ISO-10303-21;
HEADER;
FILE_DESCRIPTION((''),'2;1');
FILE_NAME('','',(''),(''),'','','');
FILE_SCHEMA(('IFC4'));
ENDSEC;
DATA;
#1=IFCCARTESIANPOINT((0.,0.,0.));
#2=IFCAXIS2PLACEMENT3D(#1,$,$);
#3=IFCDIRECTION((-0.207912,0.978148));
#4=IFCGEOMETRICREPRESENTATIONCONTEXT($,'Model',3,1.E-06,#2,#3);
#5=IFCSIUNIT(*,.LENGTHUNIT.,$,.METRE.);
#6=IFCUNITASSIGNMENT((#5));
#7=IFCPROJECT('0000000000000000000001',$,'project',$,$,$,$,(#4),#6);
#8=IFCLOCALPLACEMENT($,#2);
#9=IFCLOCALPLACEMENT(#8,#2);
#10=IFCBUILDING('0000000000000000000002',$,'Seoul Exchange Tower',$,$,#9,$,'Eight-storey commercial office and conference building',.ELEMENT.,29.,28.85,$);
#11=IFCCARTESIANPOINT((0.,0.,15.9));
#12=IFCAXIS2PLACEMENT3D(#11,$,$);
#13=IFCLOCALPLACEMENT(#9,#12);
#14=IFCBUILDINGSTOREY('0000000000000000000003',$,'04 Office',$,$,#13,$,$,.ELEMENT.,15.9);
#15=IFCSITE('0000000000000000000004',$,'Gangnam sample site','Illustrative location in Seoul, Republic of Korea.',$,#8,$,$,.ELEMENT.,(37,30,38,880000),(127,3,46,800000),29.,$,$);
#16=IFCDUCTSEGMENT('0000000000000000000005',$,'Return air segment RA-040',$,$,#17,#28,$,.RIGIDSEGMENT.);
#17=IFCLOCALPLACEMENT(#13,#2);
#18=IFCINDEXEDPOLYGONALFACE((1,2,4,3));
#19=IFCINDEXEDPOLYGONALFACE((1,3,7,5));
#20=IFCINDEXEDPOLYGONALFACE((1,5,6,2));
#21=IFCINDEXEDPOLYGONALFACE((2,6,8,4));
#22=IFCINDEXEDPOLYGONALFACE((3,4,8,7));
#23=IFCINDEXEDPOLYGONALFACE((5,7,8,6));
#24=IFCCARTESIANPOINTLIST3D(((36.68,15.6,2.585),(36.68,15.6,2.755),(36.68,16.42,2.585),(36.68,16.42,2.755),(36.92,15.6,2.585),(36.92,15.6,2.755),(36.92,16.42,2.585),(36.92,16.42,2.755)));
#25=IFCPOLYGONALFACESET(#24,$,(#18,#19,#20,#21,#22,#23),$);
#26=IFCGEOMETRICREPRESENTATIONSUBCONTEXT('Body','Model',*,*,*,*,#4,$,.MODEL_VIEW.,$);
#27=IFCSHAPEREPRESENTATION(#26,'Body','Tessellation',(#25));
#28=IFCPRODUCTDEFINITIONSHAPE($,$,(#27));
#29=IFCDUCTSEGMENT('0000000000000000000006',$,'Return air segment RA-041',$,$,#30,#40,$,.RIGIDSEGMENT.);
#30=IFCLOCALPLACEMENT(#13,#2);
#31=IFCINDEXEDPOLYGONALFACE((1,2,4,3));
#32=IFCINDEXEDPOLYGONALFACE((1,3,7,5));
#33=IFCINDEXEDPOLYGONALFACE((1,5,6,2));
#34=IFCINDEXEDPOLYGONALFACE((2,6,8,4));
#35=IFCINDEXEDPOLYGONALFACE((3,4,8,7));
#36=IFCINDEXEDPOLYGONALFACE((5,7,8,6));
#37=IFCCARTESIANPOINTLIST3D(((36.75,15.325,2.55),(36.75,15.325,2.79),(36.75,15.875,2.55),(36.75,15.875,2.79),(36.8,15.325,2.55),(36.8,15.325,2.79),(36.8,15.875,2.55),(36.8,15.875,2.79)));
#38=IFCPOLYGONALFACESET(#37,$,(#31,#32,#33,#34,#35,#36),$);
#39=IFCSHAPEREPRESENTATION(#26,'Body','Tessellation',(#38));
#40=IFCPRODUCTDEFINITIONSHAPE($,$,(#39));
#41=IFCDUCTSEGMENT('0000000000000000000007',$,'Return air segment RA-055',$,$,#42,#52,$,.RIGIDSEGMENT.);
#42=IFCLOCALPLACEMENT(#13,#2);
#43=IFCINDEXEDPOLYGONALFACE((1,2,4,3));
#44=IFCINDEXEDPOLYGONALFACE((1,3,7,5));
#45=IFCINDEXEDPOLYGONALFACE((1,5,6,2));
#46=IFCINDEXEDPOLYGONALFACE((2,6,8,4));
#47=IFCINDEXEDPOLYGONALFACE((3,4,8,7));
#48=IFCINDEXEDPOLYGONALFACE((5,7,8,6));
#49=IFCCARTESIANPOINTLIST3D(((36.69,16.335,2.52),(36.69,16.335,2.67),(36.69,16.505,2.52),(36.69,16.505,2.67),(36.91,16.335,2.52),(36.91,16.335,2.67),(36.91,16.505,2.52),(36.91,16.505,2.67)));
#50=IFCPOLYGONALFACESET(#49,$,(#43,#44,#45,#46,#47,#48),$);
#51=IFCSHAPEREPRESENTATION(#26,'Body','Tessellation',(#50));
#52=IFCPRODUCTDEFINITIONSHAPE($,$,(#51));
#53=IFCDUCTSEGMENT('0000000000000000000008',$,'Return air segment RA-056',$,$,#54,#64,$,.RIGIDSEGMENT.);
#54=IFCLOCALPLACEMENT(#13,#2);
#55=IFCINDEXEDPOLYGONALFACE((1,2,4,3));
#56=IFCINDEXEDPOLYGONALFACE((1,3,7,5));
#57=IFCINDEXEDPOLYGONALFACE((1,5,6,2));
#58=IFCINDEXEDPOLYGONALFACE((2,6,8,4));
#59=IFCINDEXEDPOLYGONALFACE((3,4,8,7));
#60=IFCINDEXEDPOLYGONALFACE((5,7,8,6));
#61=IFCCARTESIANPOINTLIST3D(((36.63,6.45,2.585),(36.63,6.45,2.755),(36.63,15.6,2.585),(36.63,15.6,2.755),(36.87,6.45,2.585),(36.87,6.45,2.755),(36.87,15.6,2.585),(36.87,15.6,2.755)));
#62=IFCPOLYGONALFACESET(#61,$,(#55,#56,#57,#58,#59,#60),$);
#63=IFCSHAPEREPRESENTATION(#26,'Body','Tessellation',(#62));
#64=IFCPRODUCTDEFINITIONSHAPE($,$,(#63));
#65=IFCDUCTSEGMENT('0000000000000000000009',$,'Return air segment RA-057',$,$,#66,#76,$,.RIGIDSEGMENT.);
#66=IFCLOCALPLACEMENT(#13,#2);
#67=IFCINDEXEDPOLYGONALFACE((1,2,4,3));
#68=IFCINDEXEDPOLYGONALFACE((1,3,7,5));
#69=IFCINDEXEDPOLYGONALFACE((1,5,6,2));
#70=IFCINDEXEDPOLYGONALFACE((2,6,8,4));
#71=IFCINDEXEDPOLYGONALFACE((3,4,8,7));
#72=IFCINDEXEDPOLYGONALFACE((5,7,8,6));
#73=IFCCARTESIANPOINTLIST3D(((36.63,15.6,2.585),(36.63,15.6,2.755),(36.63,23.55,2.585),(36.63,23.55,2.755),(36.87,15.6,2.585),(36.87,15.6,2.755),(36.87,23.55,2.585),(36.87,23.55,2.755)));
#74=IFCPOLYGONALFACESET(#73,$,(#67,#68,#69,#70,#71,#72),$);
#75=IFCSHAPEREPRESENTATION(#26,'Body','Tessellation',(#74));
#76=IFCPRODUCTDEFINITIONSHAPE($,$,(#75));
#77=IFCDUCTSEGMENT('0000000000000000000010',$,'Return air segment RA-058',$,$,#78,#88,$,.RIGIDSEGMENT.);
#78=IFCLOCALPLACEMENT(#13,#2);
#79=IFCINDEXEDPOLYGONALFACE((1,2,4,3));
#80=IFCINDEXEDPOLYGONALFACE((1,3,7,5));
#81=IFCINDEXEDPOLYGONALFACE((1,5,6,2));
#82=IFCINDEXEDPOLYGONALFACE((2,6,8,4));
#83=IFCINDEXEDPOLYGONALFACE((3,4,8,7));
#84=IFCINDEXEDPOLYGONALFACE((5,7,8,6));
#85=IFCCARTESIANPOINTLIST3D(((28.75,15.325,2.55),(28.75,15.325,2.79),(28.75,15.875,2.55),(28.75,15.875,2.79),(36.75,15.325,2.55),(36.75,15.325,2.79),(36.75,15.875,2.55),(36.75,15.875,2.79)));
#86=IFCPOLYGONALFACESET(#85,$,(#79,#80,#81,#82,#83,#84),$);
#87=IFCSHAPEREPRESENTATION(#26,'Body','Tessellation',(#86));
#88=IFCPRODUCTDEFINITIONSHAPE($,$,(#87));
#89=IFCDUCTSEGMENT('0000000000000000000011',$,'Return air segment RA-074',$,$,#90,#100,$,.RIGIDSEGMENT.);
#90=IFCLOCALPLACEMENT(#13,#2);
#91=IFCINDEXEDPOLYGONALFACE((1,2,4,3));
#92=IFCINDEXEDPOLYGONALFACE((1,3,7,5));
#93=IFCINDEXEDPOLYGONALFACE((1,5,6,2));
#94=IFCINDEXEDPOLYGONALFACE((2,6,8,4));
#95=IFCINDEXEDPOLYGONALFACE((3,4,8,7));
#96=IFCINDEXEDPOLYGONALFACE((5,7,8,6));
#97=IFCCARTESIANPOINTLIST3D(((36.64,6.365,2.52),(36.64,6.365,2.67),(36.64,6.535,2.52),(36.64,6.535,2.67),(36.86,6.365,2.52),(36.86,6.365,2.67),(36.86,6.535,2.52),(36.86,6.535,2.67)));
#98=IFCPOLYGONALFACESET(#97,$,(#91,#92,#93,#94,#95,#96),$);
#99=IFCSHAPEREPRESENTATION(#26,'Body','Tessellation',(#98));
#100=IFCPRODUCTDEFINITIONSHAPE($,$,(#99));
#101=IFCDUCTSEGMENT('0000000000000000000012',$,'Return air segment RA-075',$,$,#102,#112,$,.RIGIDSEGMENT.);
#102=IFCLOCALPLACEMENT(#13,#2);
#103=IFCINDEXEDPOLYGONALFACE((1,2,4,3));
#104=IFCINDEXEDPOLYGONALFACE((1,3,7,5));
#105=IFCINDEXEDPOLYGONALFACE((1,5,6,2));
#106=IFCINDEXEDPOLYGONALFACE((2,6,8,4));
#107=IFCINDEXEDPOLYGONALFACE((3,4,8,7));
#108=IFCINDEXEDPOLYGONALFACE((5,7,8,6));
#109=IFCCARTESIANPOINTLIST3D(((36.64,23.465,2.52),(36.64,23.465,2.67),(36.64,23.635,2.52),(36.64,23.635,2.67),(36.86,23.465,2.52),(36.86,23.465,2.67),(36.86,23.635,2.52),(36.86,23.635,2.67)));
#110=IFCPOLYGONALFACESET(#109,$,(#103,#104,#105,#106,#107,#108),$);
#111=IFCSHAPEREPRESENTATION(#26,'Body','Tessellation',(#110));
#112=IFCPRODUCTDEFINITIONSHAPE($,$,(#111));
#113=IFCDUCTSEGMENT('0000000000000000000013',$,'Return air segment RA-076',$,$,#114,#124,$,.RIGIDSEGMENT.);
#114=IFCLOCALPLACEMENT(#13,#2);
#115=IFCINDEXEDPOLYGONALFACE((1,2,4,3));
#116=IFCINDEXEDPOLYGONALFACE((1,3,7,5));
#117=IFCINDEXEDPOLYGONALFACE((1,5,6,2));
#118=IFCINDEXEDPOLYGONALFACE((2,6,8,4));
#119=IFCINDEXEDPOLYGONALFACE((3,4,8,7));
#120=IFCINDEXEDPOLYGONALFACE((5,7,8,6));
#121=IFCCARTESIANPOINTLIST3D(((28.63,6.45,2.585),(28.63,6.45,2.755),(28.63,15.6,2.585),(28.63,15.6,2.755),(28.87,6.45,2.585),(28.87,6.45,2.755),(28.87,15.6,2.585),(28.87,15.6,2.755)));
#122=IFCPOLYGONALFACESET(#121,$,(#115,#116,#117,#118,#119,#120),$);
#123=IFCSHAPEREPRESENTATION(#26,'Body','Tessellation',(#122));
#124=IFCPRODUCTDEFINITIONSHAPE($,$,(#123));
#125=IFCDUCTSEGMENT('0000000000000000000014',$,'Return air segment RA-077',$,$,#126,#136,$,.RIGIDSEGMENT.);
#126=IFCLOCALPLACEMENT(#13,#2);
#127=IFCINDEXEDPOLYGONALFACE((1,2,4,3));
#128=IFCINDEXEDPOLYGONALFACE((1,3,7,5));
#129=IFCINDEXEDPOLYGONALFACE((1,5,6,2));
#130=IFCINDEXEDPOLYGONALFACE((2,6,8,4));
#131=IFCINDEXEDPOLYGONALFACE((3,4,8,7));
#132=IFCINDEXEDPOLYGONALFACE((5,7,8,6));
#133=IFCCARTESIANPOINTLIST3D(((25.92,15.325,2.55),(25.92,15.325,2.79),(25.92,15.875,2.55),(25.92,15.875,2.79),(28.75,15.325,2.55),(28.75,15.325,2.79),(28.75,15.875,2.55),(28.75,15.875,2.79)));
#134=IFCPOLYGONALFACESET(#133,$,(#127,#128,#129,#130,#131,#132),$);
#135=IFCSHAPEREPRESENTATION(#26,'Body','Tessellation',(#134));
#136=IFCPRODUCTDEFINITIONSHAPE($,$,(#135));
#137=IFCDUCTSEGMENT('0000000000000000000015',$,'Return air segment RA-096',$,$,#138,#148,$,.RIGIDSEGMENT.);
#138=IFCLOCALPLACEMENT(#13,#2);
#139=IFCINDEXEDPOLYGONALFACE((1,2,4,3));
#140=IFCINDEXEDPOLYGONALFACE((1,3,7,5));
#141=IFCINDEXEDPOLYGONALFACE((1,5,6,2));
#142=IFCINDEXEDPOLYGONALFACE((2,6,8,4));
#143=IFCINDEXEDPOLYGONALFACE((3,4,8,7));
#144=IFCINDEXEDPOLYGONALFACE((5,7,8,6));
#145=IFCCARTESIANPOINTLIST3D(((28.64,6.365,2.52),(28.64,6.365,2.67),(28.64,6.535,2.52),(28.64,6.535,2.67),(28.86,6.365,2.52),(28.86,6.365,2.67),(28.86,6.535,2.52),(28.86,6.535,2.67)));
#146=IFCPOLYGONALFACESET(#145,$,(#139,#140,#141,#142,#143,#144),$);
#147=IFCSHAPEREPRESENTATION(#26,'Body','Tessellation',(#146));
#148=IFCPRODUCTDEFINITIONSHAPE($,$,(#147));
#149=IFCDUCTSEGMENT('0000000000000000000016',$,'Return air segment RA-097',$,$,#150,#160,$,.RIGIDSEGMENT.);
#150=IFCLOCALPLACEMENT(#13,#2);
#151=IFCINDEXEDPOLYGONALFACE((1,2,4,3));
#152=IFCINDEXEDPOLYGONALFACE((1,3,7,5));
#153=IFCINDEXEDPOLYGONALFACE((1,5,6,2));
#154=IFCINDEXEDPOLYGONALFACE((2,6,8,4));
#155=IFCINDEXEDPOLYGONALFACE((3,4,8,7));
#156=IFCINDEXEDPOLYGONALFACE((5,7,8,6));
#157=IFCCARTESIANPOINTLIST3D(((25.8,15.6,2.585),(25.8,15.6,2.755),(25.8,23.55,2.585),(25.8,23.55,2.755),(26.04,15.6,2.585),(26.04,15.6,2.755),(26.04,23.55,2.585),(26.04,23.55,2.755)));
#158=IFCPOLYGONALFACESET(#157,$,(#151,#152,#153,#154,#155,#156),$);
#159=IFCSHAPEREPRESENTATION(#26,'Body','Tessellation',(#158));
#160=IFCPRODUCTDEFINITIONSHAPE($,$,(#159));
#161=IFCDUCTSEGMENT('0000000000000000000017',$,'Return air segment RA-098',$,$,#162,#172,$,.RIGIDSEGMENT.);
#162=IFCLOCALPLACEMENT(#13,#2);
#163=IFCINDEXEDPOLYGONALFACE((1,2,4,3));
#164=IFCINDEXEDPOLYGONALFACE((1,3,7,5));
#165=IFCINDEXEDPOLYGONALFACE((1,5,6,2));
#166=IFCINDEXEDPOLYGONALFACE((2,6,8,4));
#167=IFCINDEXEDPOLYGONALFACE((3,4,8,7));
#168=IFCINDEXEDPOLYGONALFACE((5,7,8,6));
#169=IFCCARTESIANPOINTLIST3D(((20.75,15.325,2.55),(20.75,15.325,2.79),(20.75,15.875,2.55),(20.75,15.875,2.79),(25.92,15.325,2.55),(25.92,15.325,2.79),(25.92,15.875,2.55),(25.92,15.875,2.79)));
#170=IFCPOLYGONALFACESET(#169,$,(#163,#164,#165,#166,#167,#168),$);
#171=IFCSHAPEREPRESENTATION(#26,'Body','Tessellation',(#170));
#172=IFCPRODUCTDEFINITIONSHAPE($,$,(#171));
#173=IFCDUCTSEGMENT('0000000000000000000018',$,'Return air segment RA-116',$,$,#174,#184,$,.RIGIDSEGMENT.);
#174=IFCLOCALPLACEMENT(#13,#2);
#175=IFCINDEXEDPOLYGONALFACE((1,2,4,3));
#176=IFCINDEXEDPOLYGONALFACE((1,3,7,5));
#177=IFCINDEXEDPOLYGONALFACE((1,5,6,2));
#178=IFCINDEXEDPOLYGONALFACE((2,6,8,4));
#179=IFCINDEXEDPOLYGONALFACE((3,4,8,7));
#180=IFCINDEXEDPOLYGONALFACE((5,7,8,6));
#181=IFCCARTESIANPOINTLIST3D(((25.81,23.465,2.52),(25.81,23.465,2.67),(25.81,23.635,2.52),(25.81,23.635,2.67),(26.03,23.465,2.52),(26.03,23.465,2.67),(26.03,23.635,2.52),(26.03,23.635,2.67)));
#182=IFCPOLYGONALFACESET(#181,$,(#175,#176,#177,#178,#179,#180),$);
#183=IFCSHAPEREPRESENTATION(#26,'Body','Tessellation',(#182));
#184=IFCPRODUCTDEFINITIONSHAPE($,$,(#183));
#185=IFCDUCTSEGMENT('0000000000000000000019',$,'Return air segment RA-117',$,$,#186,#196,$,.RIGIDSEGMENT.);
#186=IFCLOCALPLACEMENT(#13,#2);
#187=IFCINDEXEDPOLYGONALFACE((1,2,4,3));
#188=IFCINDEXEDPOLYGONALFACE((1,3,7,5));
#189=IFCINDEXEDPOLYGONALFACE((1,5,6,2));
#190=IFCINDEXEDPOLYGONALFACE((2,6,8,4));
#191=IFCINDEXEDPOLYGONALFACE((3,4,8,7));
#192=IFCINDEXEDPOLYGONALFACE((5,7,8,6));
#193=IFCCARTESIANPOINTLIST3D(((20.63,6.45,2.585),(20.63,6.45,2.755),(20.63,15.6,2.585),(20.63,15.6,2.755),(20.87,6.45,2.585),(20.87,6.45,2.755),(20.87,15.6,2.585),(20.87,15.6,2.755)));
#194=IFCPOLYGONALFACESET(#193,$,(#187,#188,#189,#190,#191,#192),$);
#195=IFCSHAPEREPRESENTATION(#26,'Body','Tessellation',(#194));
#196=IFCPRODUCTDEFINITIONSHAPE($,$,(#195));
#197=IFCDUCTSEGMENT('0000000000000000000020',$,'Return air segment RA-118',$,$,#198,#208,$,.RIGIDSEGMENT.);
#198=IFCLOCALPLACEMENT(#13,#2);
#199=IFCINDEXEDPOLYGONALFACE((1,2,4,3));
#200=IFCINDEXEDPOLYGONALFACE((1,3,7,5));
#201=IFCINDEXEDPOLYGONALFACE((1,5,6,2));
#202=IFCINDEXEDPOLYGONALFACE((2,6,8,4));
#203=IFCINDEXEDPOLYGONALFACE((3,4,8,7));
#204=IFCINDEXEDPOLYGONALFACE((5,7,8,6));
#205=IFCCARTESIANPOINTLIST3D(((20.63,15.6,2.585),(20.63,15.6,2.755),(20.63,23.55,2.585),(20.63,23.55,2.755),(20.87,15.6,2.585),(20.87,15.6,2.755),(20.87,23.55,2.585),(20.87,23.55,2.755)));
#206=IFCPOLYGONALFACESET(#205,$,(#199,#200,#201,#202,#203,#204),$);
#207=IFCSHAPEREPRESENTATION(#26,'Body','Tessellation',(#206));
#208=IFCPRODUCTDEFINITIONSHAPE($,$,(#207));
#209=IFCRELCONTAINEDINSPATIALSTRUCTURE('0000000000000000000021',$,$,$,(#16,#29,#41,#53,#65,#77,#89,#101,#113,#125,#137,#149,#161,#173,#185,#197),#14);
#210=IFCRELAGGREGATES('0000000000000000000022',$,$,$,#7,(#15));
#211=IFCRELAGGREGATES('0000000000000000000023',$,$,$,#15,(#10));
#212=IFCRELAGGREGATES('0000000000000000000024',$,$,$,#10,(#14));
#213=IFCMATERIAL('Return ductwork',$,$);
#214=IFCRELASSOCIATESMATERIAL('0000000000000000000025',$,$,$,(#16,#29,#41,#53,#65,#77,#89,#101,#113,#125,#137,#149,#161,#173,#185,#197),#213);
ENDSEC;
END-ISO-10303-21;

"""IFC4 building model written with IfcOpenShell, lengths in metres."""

from ifc_helpers import new_model, si_unit, direction, frame, origin, place, context, subcontext, project, spatial, rectangle, extrude, material, element, save


model = new_model("IFC4")

# Units and contexts
model_context = context("Model", 3, precision=1e-06, world=origin(), true_north=direction((-0.207912, 0.978148)))
body_context = subcontext(model_context, "Body", "Model", "MODEL_VIEW")
ifc_project = project(units=[si_unit("LENGTHUNIT", "METRE")], contexts=[model_context])

# Site, building, storey
site_placement = place(None, origin())
site = spatial("IfcSite", under=ifc_project, at=site_placement, Name="Gangnam sample site", Description="Illustrative location in Seoul, Republic of Korea.", CompositionType="ELEMENT", RefLatitude=(37, 30, 38, 880000), RefLongitude=(127, 3, 46, 800000), RefElevation=29.0)
building_placement = place(site_placement, origin())
building = spatial("IfcBuilding", under=site, at=building_placement, Name="Seoul Exchange Tower", LongName="Eight-storey commercial office and conference building", CompositionType="ELEMENT", ElevationOfRefHeight=29.0, ElevationOfTerrain=28.85)
storey_placement = place(building_placement, frame((0.0, 0.0, 15.9)))
storey = spatial("IfcBuildingStorey", under=building, at=storey_placement, Name="04 Office", CompositionType="ELEMENT", Elevation=15.9)

# Shared definitions
ifc_material = material(Name="Return ductwork")
placement = place(storey_placement, origin())

# Duct segments
element("IfcDuctSegment", 1, at=placement, inside=storey, material=ifc_material, Name="Return air segment RA-040", PredefinedType="RIGIDSEGMENT", context=body_context, shape_type="SweptSolid", body=[
    extrude(rectangle(XDim=0.24, YDim=0.17), frame((36.8, 16.42, 2.67), z_axis=(0.0, -1.0, 0.0), x_axis=(1.0, 0.0, 0.0)), (0.0, 0.0, 1.0), 0.82),
])
element("IfcDuctSegment", 2, at=placement, inside=storey, material=ifc_material, Name="Return air segment RA-041", PredefinedType="RIGIDSEGMENT", context=body_context, shape_type="SweptSolid", body=[
    extrude(rectangle(XDim=0.55, YDim=0.24), frame((36.75, 15.6, 2.67), z_axis=(1.0, 0.0, 0.0), x_axis=(0.0, 1.0, 0.0)), (0.0, 0.0, 1.0), 0.05),
])
element("IfcDuctSegment", 3, at=placement, inside=storey, material=ifc_material, Name="Return air segment RA-055", PredefinedType="RIGIDSEGMENT", context=body_context, shape_type="SweptSolid", body=[
    extrude(rectangle(XDim=0.22, YDim=0.17), frame((36.8, 16.42, 2.52), z_axis=(0.0, 0.0, 1.0), x_axis=(1.0, 0.0, 0.0)), (0.0, 0.0, 1.0), 0.15),
])
element("IfcDuctSegment", 4, at=placement, inside=storey, material=ifc_material, Name="Return air segment RA-056", PredefinedType="RIGIDSEGMENT", context=body_context, shape_type="SweptSolid", body=[
    extrude(rectangle(XDim=0.24, YDim=0.17), frame((36.75, 6.45, 2.67), z_axis=(0.0, 1.0, 0.0), x_axis=(1.0, 0.0, 0.0)), (0.0, 0.0, 1.0), 9.15),
])
element("IfcDuctSegment", 5, at=placement, inside=storey, material=ifc_material, Name="Return air segment RA-057", PredefinedType="RIGIDSEGMENT", context=body_context, shape_type="SweptSolid", body=[
    extrude(rectangle(XDim=0.24, YDim=0.17), frame((36.75, 23.55, 2.67), z_axis=(0.0, -1.0, 0.0), x_axis=(1.0, 0.0, 0.0)), (0.0, 0.0, 1.0), 7.95),
])
element("IfcDuctSegment", 6, at=placement, inside=storey, material=ifc_material, Name="Return air segment RA-058", PredefinedType="RIGIDSEGMENT", context=body_context, shape_type="SweptSolid", body=[
    extrude(rectangle(XDim=0.55, YDim=0.24), frame((28.75, 15.6, 2.67), z_axis=(1.0, 0.0, 0.0), x_axis=(0.0, 1.0, 0.0)), (0.0, 0.0, 1.0), 8.0),
])
element("IfcDuctSegment", 7, at=placement, inside=storey, material=ifc_material, Name="Return air segment RA-074", PredefinedType="RIGIDSEGMENT", context=body_context, shape_type="SweptSolid", body=[
    extrude(rectangle(XDim=0.22, YDim=0.17), frame((36.75, 6.45, 2.52), z_axis=(0.0, 0.0, 1.0), x_axis=(1.0, 0.0, 0.0)), (0.0, 0.0, 1.0), 0.15),
])
element("IfcDuctSegment", 8, at=placement, inside=storey, material=ifc_material, Name="Return air segment RA-075", PredefinedType="RIGIDSEGMENT", context=body_context, shape_type="SweptSolid", body=[
    extrude(rectangle(XDim=0.22, YDim=0.17), frame((36.75, 23.55, 2.52), z_axis=(0.0, 0.0, 1.0), x_axis=(1.0, 0.0, 0.0)), (0.0, 0.0, 1.0), 0.15),
])
element("IfcDuctSegment", 9, at=placement, inside=storey, material=ifc_material, Name="Return air segment RA-076", PredefinedType="RIGIDSEGMENT", context=body_context, shape_type="SweptSolid", body=[
    extrude(rectangle(XDim=0.24, YDim=0.17), frame((28.75, 6.45, 2.67), z_axis=(0.0, 1.0, 0.0), x_axis=(1.0, 0.0, 0.0)), (0.0, 0.0, 1.0), 9.15),
])
element("IfcDuctSegment", 10, at=placement, inside=storey, material=ifc_material, Name="Return air segment RA-077", PredefinedType="RIGIDSEGMENT", context=body_context, shape_type="SweptSolid", body=[
    extrude(rectangle(XDim=0.55, YDim=0.24), frame((25.92, 15.6, 2.67), z_axis=(1.0, 0.0, 0.0), x_axis=(0.0, 1.0, 0.0)), (0.0, 0.0, 1.0), 2.83),
])
element("IfcDuctSegment", 11, at=placement, inside=storey, material=ifc_material, Name="Return air segment RA-096", PredefinedType="RIGIDSEGMENT", context=body_context, shape_type="SweptSolid", body=[
    extrude(rectangle(XDim=0.22, YDim=0.17), frame((28.75, 6.45, 2.52), z_axis=(0.0, 0.0, 1.0), x_axis=(1.0, 0.0, 0.0)), (0.0, 0.0, 1.0), 0.15),
])
element("IfcDuctSegment", 12, at=placement, inside=storey, material=ifc_material, Name="Return air segment RA-097", PredefinedType="RIGIDSEGMENT", context=body_context, shape_type="SweptSolid", body=[
    extrude(rectangle(XDim=0.24, YDim=0.17), frame((25.92, 23.55, 2.67), z_axis=(0.0, -1.0, 0.0), x_axis=(1.0, 0.0, 0.0)), (0.0, 0.0, 1.0), 7.95),
])
element("IfcDuctSegment", 13, at=placement, inside=storey, material=ifc_material, Name="Return air segment RA-098", PredefinedType="RIGIDSEGMENT", context=body_context, shape_type="SweptSolid", body=[
    extrude(rectangle(XDim=0.55, YDim=0.24), frame((20.75, 15.6, 2.67), z_axis=(1.0, 0.0, 0.0), x_axis=(0.0, 1.0, 0.0)), (0.0, 0.0, 1.0), 5.17),
])
element("IfcDuctSegment", 14, at=placement, inside=storey, material=ifc_material, Name="Return air segment RA-116", PredefinedType="RIGIDSEGMENT", context=body_context, shape_type="SweptSolid", body=[
    extrude(rectangle(XDim=0.22, YDim=0.17), frame((25.92, 23.55, 2.52), z_axis=(0.0, 0.0, 1.0), x_axis=(1.0, 0.0, 0.0)), (0.0, 0.0, 1.0), 0.15),
])
element("IfcDuctSegment", 15, at=placement, inside=storey, material=ifc_material, Name="Return air segment RA-117", PredefinedType="RIGIDSEGMENT", context=body_context, shape_type="SweptSolid", body=[
    extrude(rectangle(XDim=0.24, YDim=0.17), frame((20.75, 6.45, 2.67), z_axis=(0.0, 1.0, 0.0), x_axis=(1.0, 0.0, 0.0)), (0.0, 0.0, 1.0), 9.15),
])
element("IfcDuctSegment", 16, at=placement, inside=storey, material=ifc_material, Name="Return air segment RA-118", PredefinedType="RIGIDSEGMENT", context=body_context, shape_type="SweptSolid", body=[
    extrude(rectangle(XDim=0.24, YDim=0.17), frame((20.75, 23.55, 2.67), z_axis=(0.0, -1.0, 0.0), x_axis=(1.0, 0.0, 0.0)), (0.0, 0.0, 1.0), 7.95),
])

save(model, "model.ifc")
